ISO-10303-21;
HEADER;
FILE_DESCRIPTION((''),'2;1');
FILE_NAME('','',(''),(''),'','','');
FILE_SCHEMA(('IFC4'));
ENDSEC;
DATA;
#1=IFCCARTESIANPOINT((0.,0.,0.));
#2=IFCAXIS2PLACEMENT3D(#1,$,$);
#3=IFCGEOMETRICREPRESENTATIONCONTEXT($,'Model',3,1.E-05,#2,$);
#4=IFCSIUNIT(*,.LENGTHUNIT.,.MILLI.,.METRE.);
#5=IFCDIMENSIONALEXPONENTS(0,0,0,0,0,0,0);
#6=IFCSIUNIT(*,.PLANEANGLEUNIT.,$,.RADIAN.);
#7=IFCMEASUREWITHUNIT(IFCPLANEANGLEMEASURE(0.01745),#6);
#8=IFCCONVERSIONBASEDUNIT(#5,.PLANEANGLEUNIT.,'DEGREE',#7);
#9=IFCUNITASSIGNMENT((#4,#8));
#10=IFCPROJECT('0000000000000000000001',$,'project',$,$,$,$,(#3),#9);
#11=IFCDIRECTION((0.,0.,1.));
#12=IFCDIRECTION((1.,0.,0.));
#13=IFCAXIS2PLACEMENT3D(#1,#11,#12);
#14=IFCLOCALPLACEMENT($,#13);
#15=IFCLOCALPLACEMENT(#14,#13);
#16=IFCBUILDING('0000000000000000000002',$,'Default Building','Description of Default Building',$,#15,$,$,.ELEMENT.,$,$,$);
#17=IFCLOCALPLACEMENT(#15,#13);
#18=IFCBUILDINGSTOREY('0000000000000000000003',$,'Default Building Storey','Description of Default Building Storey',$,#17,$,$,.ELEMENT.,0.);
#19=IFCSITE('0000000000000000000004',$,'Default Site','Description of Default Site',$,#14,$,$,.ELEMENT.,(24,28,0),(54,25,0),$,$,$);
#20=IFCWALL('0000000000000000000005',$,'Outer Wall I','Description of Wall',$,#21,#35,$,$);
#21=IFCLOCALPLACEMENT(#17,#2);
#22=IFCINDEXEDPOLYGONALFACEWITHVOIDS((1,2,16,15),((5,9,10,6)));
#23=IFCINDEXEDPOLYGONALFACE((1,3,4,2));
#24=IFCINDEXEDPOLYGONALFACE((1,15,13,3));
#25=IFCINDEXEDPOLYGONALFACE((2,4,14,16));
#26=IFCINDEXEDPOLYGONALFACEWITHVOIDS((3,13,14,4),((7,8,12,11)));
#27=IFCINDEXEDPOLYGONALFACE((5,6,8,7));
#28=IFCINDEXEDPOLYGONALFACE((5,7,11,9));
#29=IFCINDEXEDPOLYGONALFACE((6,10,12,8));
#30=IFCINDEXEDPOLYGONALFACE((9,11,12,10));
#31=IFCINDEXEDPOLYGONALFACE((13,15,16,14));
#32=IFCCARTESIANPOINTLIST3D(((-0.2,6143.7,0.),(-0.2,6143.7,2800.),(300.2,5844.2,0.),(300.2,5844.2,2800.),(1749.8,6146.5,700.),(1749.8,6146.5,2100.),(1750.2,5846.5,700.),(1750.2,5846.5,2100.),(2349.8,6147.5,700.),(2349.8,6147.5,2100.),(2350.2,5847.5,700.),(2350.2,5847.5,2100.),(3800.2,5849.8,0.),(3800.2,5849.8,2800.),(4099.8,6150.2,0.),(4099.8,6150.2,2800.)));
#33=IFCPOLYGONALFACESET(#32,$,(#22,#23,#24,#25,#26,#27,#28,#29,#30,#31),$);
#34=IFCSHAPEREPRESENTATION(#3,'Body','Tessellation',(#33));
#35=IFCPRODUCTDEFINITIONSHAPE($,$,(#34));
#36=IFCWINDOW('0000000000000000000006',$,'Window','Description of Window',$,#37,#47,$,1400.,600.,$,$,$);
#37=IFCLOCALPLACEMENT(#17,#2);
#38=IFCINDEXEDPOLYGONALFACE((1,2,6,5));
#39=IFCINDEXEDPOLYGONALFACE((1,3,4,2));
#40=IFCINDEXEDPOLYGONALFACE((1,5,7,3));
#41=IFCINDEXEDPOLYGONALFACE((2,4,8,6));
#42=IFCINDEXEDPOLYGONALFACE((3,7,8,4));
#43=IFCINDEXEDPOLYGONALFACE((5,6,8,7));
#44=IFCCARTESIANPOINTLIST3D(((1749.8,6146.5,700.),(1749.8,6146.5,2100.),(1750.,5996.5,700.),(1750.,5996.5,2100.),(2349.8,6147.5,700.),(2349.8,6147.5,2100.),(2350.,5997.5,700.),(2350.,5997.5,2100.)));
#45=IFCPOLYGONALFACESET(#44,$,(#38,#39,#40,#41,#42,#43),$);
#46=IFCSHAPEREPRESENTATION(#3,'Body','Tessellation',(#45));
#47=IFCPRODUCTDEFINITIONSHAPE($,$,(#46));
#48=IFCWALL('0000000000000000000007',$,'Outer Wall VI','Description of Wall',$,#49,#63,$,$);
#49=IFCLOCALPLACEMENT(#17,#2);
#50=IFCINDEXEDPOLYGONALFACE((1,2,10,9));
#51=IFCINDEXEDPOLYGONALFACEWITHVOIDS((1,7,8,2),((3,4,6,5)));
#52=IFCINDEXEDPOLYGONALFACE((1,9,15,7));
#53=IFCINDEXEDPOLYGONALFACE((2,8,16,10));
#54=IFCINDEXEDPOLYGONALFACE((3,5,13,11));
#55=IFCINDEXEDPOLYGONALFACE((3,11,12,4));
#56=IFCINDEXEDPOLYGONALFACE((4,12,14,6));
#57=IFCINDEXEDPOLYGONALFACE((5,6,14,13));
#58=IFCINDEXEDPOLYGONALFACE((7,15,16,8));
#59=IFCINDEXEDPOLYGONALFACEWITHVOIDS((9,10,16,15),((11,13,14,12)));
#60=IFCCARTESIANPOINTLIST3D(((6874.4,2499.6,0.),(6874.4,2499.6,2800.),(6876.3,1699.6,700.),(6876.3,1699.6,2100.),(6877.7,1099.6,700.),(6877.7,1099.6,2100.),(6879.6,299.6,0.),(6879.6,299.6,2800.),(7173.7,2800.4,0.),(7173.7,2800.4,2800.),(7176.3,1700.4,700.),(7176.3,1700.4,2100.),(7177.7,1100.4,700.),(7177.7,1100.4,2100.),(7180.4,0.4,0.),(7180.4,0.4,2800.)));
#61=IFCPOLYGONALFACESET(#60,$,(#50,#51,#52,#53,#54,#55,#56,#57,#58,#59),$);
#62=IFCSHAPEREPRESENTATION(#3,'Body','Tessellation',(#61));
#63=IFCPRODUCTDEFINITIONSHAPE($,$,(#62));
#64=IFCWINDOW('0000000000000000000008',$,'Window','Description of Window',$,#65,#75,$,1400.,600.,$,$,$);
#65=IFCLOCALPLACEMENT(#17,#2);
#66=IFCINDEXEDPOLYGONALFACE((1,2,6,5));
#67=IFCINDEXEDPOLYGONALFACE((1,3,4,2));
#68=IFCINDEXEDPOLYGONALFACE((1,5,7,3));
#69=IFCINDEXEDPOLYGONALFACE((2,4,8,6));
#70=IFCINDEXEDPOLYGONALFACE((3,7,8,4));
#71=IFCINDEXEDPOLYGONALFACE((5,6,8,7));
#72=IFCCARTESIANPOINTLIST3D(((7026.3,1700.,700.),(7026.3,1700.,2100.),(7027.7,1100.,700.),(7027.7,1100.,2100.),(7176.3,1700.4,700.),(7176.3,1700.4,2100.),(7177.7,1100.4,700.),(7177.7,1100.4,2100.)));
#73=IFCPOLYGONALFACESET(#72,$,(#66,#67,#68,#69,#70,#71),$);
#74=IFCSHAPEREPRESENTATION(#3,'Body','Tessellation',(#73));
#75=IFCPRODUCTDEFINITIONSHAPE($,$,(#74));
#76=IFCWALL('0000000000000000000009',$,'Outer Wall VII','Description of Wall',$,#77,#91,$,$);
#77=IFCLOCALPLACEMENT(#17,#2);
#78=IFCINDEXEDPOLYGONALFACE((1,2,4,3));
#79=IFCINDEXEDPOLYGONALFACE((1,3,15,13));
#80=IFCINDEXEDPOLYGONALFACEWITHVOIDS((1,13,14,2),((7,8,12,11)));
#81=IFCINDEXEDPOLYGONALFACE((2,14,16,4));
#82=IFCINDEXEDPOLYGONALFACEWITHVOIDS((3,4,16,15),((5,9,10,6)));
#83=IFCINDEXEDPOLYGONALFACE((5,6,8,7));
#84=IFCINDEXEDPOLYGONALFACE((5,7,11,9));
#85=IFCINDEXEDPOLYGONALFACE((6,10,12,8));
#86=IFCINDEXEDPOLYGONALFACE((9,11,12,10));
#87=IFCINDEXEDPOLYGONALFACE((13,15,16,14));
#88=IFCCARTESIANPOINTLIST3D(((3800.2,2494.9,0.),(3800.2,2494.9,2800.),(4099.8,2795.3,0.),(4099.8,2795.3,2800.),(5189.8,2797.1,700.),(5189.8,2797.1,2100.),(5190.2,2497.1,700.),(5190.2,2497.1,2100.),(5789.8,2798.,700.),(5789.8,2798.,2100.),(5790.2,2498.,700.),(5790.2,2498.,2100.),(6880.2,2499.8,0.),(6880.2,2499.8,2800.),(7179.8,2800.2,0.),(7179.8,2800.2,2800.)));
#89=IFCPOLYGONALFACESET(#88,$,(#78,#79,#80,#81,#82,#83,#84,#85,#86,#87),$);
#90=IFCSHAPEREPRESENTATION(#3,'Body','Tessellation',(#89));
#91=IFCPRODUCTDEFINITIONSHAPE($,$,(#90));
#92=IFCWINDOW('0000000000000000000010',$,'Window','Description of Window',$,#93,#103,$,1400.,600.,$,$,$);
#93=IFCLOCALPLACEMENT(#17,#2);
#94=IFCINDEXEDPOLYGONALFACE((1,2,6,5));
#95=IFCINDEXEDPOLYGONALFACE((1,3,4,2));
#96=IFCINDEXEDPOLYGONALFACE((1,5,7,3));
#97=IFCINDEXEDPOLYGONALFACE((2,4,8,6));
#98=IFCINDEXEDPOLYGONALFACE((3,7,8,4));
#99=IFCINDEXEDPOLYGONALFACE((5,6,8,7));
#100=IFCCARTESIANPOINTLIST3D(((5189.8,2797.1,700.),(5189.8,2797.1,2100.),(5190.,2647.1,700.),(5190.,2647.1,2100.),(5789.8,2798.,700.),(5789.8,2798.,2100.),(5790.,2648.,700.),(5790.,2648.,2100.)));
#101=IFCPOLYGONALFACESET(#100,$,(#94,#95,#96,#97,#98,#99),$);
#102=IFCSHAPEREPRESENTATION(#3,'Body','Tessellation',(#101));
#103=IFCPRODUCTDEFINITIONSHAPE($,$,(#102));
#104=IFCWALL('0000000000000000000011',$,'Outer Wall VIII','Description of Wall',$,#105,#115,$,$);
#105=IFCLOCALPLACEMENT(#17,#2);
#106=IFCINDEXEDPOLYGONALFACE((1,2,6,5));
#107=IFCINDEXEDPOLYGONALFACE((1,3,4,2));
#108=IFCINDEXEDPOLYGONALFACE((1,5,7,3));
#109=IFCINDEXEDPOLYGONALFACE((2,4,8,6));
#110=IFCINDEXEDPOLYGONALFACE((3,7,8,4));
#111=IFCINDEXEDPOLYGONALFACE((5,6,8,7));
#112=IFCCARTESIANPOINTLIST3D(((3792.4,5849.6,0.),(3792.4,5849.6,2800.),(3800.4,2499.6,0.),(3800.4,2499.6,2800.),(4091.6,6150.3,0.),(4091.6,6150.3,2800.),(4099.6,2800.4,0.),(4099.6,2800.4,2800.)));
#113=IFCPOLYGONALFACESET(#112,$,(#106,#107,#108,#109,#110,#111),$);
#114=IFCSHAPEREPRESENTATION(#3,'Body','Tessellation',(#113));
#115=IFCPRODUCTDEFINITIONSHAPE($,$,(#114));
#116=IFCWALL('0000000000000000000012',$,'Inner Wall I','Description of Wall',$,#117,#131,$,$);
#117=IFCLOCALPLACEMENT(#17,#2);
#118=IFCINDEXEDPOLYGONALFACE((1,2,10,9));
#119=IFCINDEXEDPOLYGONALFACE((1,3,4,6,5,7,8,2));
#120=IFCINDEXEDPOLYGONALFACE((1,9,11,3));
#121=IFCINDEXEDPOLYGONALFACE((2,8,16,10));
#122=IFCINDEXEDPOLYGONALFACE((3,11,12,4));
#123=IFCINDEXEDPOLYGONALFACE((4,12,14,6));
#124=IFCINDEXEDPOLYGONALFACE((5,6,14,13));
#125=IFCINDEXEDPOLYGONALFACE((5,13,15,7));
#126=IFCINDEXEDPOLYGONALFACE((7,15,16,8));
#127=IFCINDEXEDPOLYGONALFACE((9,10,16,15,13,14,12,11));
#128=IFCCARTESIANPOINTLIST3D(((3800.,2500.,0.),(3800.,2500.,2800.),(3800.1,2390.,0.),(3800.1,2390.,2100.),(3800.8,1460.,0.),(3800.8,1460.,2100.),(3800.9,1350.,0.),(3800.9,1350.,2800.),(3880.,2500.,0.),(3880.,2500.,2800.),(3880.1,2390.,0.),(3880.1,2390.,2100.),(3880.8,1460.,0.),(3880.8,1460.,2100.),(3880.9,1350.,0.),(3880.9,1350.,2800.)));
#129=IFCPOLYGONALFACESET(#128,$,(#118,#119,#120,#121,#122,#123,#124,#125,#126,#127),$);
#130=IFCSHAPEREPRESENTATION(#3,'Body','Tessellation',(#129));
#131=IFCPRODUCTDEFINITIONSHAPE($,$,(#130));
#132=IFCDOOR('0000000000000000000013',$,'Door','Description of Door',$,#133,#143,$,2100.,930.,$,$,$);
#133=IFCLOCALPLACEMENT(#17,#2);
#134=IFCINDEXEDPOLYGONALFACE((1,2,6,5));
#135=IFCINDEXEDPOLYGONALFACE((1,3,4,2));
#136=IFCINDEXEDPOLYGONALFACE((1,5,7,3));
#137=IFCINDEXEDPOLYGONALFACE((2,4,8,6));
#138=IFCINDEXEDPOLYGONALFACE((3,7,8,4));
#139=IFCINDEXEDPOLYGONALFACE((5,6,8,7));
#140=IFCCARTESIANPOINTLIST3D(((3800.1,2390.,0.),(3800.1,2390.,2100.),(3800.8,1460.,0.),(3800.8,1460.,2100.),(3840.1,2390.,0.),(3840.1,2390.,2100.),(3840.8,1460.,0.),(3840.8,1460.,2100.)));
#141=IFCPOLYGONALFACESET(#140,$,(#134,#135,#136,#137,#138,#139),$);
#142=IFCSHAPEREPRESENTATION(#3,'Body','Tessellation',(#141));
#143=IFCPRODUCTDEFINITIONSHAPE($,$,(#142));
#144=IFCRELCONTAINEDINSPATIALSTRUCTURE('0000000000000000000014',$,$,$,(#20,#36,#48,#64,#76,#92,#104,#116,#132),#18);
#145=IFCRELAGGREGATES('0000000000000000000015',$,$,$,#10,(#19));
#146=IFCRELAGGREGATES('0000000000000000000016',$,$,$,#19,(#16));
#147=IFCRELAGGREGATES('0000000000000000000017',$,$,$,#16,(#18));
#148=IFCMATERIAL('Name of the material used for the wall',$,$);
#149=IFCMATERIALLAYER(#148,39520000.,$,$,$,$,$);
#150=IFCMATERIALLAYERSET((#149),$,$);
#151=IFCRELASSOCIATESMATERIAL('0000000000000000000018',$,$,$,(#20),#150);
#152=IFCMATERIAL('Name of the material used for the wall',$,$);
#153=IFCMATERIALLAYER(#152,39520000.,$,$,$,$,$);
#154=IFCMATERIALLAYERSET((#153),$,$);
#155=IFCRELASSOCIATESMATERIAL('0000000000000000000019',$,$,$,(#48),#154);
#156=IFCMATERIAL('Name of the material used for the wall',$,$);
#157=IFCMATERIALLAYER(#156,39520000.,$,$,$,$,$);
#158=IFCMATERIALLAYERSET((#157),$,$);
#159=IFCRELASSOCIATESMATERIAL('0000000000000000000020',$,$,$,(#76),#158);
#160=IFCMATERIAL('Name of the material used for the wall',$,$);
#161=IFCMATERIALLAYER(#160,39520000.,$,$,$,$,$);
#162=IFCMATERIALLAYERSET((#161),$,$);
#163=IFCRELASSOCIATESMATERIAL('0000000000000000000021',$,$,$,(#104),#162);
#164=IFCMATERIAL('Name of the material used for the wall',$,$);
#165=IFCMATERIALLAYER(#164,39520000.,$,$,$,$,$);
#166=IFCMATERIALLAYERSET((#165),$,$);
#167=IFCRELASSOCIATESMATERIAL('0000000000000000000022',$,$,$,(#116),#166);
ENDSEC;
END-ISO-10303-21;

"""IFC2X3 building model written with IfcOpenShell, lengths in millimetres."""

from ifc_helpers import new_model, entity, si_unit, converted_unit, frame, origin, origin_with_axes, place, context, project, spatial, polyline, outline, extrude, material, layer, layer_set, layer_usage, element, fill, save


model = new_model("IFC2X3")

# Units and contexts
model_context = context("Model", 3, precision=1e-05, world=origin())
ifc_project = project(units=[si_unit("LENGTHUNIT", "METRE", prefix="MILLI"), converted_unit("PLANEANGLEUNIT", "DEGREE", entity("IfcPlaneAngleMeasure", 0.01745), si_unit("PLANEANGLEUNIT", "RADIAN"), dimensions=[0, 0, 0, 0, 0, 0, 0])], contexts=[model_context])

# Site, building, storey
site_placement = place(None, origin_with_axes())
site = spatial("IfcSite", under=ifc_project, at=site_placement, Name="Default Site", Description="Description of Default Site", CompositionType="ELEMENT", RefLatitude=(24, 28, 0), RefLongitude=(54, 25, 0))
building_placement = place(site_placement, origin_with_axes())
building = spatial("IfcBuilding", under=site, at=building_placement, Name="Default Building", Description="Description of Default Building", CompositionType="ELEMENT")
storey_placement = place(building_placement, origin_with_axes())
storey = spatial("IfcBuildingStorey", under=building, at=storey_placement, Name="Default Building Storey", Description="Description of Default Building Storey", CompositionType="ELEMENT", Elevation=0.0)

# Walls, openings, windows
ifc_material_1 = material(Name="Name of the material used for the wall")
ifc_layer_1 = layer(ifc_material_1, 39520000.0)
ifc_layer_set_1 = layer_set([ifc_layer_1])
ifc_layer_usage_1 = layer_usage(ifc_layer_set_1, "AXIS2", "POSITIVE", -19760000.0)
wall_1_placement = place(storey_placement, frame((3950.0, 6000.0, 0.0), z_axis=(0.0, 0.0, 1.0), x_axis=(-1.0, -0.001593, 0.0)))
wall_1 = element("IfcWall", 1, at=wall_1_placement, inside=storey, material=ifc_layer_usage_1, Name="Outer Wall I", Description="Description of Wall", context=model_context, shape_type="SweptSolid", body=[
    extrude(outline(polyline([(-150.0, -150.0), (150.0, 150.0), (3650.0, 150.0), (3950.0, -150.0), (-150.0, -150.0)])), origin_with_axes(), (0.0, 0.0, 1.0), 2800.0),
])
opening_1_placement = place(wall_1_placement, frame((1600.0, -150.0, 700.0), z_axis=(0.0, 0.0, 1.0), x_axis=(1.0, 0.0, 0.0)))
opening_1 = element("IfcOpeningElement", 2, at=opening_1_placement, cuts=wall_1, context=model_context, shape_type="SweptSolid", body=[
    extrude(outline(polyline([(0.0, 0.0), (0.0, 300.0), (600.0, 300.0), (600.0, 0.0), (0.0, 0.0)])), origin_with_axes(), (0.0, 0.0, 1.0), 1400.0),
])
window_1_placement = place(opening_1_placement, origin_with_axes())
window_1 = element("IfcWindow", 3, at=window_1_placement, inside=storey, Name="Window", Description="Description of Window", OverallHeight=1400.0, OverallWidth=600.0, context=model_context, shape_type="SweptSolid", body=[
    extrude(outline(polyline([(0.0, 0.0), (0.0, 150.0), (600.0, 150.0), (600.0, 0.0), (0.0, 0.0)])), origin_with_axes(), (0.0, 0.0, 1.0), 1400.0),
])
fill(opening_1, window_1)
ifc_material_2 = material(Name="Name of the material used for the wall")
ifc_layer_2 = layer(ifc_material_2, 39520000.0)
ifc_layer_set_2 = layer_set([ifc_layer_2])
ifc_layer_usage_2 = layer_usage(ifc_layer_set_2, "AXIS2", "POSITIVE", -19760000.0)
wall_2_placement = place(storey_placement, frame((7030.0, 150.0, 0.0), z_axis=(0.0, 0.0, 1.0), x_axis=(-0.002389, 1.0, 0.0)))
wall_2 = element("IfcWall", 4, at=wall_2_placement, inside=storey, material=ifc_layer_usage_2, Name="Outer Wall VI", Description="Description of Wall", context=model_context, shape_type="SweptSolid", body=[
    extrude(outline(polyline([(-150.0, -150.0), (150.0, 150.0), (2350.0, 150.0), (2650.0, -150.0), (-150.0, -150.0)])), origin_with_axes(), (0.0, 0.0, 1.0), 2800.0),
])
opening_2_placement = place(wall_2_placement, frame((950.0, -150.0, 700.0), z_axis=(0.0, 0.0, 1.0), x_axis=(1.0, 0.0, 0.0)))
opening_2 = element("IfcOpeningElement", 5, at=opening_2_placement, cuts=wall_2, context=model_context, shape_type="SweptSolid", body=[
    extrude(outline(polyline([(0.0, 0.0), (0.0, 300.0), (600.0, 300.0), (600.0, 0.0), (0.0, 0.0)])), origin_with_axes(), (0.0, 0.0, 1.0), 1400.0),
])
window_2_placement = place(opening_2_placement, origin_with_axes())
window_2 = element("IfcWindow", 6, at=window_2_placement, inside=storey, Name="Window", Description="Description of Window", OverallHeight=1400.0, OverallWidth=600.0, context=model_context, shape_type="SweptSolid", body=[
    extrude(outline(polyline([(0.0, 0.0), (0.0, 150.0), (600.0, 150.0), (600.0, 0.0), (0.0, 0.0)])), origin_with_axes(), (0.0, 0.0, 1.0), 1400.0),
])
fill(opening_2, window_2)
ifc_material_3 = material(Name="Name of the material used for the wall")
ifc_layer_3 = layer(ifc_material_3, 39520000.0)
ifc_layer_set_3 = layer_set([ifc_layer_3])
ifc_layer_usage_3 = layer_usage(ifc_layer_set_3, "AXIS2", "POSITIVE", -19760000.0)
wall_3_placement = place(storey_placement, frame((7030.0, 2650.0, 0.0), z_axis=(0.0, 0.0, 1.0), x_axis=(-1.0, -0.001593, 0.0)))
wall_3 = element("IfcWall", 7, at=wall_3_placement, inside=storey, material=ifc_layer_usage_3, Name="Outer Wall VII", Description="Description of Wall", context=model_context, shape_type="SweptSolid", body=[
    extrude(outline(polyline([(-150.0, -150.0), (150.0, 150.0), (3230.0, 150.0), (2930.0, -150.0), (-150.0, -150.0)])), origin_with_axes(), (0.0, 0.0, 1.0), 2800.0),
])
opening_3_placement = place(wall_3_placement, frame((1240.0, -150.0, 700.0), z_axis=(0.0, 0.0, 1.0), x_axis=(1.0, 0.0, 0.0)))
opening_3 = element("IfcOpeningElement", 8, at=opening_3_placement, cuts=wall_3, context=model_context, shape_type="SweptSolid", body=[
    extrude(outline(polyline([(0.0, 0.0), (0.0, 300.0), (600.0, 300.0), (600.0, 0.0), (0.0, 0.0)])), origin_with_axes(), (0.0, 0.0, 1.0), 1400.0),
])
window_3_placement = place(opening_3_placement, origin_with_axes())
window_3 = element("IfcWindow", 9, at=window_3_placement, inside=storey, Name="Window", Description="Description of Window", OverallHeight=1400.0, OverallWidth=600.0, context=model_context, shape_type="SweptSolid", body=[
    extrude(outline(polyline([(0.0, 0.0), (0.0, 150.0), (600.0, 150.0), (600.0, 0.0), (0.0, 0.0)])), origin_with_axes(), (0.0, 0.0, 1.0), 1400.0),
])
fill(opening_3, window_3)

# Wall
ifc_material_4 = material(Name="Name of the material used for the wall")
ifc_layer_4 = layer(ifc_material_4, 39520000.0)
ifc_layer_set_4 = layer_set([ifc_layer_4])
ifc_layer_usage_4 = layer_usage(ifc_layer_set_4, "AXIS2", "POSITIVE", -19760000.0)
wall_4_placement = place(storey_placement, frame((3950.0, 2650.0, 0.0), z_axis=(0.0, 0.0, 1.0), x_axis=(-0.002389, 1.0, 0.0)))
element("IfcWall", 10, at=wall_4_placement, inside=storey, material=ifc_layer_usage_4, Name="Outer Wall VIII", Description="Description of Wall", context=model_context, shape_type="SweptSolid", body=[
    extrude(outline(polyline([(150.0, -150.0), (-150.0, 150.0), (3200.0, 150.0), (3500.0, -150.0), (150.0, -150.0)])), origin_with_axes(), (0.0, 0.0, 1.0), 2800.0),
])

# Wall, opening, door
ifc_material_5 = material(Name="Name of the material used for the wall")
ifc_layer_5 = layer(ifc_material_5, 39520000.0)
ifc_layer_set_5 = layer_set([ifc_layer_5])
ifc_layer_usage_5 = layer_usage(ifc_layer_set_5, "AXIS2", "POSITIVE", -19760000.0)
wall_5_placement = place(storey_placement, frame((3840.0, 2500.0, 0.0), z_axis=(0.0, 0.0, 1.0), x_axis=(0.000796, -1.0, 0.0)))
wall_5 = element("IfcWall", 11, at=wall_5_placement, inside=storey, material=ifc_layer_usage_5, Name="Inner Wall I", Description="Description of Wall", context=model_context, shape_type="SweptSolid", body=[
    extrude(outline(polyline([(0.0, -40.0), (0.0, 40.0), (1150.0, 40.0), (1150.0, -40.0), (0.0, -40.0)])), origin_with_axes(), (0.0, 0.0, 1.0), 2800.0),
])
opening_4_placement = place(wall_5_placement, frame((110.0, -40.0, 0.0), z_axis=(0.0, 0.0, 1.0), x_axis=(1.0, 0.0, 0.0)))
opening_4 = element("IfcOpeningElement", 12, at=opening_4_placement, cuts=wall_5, context=model_context, shape_type="SweptSolid", body=[
    extrude(outline(polyline([(0.0, 0.0), (0.0, 80.0), (930.0, 80.0), (930.0, 0.0), (0.0, 0.0)])), origin_with_axes(), (0.0, 0.0, 1.0), 2100.0),
])
door_1_placement = place(opening_4_placement, origin_with_axes())
door_1 = element("IfcDoor", 13, at=door_1_placement, inside=storey, Name="Door", Description="Description of Door", OverallHeight=2100.0, OverallWidth=930.0, context=model_context, shape_type="SweptSolid", body=[
    extrude(outline(polyline([(0.0, 0.0), (0.0, 40.0), (930.0, 40.0), (930.0, 0.0), (0.0, 0.0)])), origin_with_axes(), (0.0, 0.0, 1.0), 2100.0),
])
fill(opening_4, door_1)

save(model, "model.ifc")
